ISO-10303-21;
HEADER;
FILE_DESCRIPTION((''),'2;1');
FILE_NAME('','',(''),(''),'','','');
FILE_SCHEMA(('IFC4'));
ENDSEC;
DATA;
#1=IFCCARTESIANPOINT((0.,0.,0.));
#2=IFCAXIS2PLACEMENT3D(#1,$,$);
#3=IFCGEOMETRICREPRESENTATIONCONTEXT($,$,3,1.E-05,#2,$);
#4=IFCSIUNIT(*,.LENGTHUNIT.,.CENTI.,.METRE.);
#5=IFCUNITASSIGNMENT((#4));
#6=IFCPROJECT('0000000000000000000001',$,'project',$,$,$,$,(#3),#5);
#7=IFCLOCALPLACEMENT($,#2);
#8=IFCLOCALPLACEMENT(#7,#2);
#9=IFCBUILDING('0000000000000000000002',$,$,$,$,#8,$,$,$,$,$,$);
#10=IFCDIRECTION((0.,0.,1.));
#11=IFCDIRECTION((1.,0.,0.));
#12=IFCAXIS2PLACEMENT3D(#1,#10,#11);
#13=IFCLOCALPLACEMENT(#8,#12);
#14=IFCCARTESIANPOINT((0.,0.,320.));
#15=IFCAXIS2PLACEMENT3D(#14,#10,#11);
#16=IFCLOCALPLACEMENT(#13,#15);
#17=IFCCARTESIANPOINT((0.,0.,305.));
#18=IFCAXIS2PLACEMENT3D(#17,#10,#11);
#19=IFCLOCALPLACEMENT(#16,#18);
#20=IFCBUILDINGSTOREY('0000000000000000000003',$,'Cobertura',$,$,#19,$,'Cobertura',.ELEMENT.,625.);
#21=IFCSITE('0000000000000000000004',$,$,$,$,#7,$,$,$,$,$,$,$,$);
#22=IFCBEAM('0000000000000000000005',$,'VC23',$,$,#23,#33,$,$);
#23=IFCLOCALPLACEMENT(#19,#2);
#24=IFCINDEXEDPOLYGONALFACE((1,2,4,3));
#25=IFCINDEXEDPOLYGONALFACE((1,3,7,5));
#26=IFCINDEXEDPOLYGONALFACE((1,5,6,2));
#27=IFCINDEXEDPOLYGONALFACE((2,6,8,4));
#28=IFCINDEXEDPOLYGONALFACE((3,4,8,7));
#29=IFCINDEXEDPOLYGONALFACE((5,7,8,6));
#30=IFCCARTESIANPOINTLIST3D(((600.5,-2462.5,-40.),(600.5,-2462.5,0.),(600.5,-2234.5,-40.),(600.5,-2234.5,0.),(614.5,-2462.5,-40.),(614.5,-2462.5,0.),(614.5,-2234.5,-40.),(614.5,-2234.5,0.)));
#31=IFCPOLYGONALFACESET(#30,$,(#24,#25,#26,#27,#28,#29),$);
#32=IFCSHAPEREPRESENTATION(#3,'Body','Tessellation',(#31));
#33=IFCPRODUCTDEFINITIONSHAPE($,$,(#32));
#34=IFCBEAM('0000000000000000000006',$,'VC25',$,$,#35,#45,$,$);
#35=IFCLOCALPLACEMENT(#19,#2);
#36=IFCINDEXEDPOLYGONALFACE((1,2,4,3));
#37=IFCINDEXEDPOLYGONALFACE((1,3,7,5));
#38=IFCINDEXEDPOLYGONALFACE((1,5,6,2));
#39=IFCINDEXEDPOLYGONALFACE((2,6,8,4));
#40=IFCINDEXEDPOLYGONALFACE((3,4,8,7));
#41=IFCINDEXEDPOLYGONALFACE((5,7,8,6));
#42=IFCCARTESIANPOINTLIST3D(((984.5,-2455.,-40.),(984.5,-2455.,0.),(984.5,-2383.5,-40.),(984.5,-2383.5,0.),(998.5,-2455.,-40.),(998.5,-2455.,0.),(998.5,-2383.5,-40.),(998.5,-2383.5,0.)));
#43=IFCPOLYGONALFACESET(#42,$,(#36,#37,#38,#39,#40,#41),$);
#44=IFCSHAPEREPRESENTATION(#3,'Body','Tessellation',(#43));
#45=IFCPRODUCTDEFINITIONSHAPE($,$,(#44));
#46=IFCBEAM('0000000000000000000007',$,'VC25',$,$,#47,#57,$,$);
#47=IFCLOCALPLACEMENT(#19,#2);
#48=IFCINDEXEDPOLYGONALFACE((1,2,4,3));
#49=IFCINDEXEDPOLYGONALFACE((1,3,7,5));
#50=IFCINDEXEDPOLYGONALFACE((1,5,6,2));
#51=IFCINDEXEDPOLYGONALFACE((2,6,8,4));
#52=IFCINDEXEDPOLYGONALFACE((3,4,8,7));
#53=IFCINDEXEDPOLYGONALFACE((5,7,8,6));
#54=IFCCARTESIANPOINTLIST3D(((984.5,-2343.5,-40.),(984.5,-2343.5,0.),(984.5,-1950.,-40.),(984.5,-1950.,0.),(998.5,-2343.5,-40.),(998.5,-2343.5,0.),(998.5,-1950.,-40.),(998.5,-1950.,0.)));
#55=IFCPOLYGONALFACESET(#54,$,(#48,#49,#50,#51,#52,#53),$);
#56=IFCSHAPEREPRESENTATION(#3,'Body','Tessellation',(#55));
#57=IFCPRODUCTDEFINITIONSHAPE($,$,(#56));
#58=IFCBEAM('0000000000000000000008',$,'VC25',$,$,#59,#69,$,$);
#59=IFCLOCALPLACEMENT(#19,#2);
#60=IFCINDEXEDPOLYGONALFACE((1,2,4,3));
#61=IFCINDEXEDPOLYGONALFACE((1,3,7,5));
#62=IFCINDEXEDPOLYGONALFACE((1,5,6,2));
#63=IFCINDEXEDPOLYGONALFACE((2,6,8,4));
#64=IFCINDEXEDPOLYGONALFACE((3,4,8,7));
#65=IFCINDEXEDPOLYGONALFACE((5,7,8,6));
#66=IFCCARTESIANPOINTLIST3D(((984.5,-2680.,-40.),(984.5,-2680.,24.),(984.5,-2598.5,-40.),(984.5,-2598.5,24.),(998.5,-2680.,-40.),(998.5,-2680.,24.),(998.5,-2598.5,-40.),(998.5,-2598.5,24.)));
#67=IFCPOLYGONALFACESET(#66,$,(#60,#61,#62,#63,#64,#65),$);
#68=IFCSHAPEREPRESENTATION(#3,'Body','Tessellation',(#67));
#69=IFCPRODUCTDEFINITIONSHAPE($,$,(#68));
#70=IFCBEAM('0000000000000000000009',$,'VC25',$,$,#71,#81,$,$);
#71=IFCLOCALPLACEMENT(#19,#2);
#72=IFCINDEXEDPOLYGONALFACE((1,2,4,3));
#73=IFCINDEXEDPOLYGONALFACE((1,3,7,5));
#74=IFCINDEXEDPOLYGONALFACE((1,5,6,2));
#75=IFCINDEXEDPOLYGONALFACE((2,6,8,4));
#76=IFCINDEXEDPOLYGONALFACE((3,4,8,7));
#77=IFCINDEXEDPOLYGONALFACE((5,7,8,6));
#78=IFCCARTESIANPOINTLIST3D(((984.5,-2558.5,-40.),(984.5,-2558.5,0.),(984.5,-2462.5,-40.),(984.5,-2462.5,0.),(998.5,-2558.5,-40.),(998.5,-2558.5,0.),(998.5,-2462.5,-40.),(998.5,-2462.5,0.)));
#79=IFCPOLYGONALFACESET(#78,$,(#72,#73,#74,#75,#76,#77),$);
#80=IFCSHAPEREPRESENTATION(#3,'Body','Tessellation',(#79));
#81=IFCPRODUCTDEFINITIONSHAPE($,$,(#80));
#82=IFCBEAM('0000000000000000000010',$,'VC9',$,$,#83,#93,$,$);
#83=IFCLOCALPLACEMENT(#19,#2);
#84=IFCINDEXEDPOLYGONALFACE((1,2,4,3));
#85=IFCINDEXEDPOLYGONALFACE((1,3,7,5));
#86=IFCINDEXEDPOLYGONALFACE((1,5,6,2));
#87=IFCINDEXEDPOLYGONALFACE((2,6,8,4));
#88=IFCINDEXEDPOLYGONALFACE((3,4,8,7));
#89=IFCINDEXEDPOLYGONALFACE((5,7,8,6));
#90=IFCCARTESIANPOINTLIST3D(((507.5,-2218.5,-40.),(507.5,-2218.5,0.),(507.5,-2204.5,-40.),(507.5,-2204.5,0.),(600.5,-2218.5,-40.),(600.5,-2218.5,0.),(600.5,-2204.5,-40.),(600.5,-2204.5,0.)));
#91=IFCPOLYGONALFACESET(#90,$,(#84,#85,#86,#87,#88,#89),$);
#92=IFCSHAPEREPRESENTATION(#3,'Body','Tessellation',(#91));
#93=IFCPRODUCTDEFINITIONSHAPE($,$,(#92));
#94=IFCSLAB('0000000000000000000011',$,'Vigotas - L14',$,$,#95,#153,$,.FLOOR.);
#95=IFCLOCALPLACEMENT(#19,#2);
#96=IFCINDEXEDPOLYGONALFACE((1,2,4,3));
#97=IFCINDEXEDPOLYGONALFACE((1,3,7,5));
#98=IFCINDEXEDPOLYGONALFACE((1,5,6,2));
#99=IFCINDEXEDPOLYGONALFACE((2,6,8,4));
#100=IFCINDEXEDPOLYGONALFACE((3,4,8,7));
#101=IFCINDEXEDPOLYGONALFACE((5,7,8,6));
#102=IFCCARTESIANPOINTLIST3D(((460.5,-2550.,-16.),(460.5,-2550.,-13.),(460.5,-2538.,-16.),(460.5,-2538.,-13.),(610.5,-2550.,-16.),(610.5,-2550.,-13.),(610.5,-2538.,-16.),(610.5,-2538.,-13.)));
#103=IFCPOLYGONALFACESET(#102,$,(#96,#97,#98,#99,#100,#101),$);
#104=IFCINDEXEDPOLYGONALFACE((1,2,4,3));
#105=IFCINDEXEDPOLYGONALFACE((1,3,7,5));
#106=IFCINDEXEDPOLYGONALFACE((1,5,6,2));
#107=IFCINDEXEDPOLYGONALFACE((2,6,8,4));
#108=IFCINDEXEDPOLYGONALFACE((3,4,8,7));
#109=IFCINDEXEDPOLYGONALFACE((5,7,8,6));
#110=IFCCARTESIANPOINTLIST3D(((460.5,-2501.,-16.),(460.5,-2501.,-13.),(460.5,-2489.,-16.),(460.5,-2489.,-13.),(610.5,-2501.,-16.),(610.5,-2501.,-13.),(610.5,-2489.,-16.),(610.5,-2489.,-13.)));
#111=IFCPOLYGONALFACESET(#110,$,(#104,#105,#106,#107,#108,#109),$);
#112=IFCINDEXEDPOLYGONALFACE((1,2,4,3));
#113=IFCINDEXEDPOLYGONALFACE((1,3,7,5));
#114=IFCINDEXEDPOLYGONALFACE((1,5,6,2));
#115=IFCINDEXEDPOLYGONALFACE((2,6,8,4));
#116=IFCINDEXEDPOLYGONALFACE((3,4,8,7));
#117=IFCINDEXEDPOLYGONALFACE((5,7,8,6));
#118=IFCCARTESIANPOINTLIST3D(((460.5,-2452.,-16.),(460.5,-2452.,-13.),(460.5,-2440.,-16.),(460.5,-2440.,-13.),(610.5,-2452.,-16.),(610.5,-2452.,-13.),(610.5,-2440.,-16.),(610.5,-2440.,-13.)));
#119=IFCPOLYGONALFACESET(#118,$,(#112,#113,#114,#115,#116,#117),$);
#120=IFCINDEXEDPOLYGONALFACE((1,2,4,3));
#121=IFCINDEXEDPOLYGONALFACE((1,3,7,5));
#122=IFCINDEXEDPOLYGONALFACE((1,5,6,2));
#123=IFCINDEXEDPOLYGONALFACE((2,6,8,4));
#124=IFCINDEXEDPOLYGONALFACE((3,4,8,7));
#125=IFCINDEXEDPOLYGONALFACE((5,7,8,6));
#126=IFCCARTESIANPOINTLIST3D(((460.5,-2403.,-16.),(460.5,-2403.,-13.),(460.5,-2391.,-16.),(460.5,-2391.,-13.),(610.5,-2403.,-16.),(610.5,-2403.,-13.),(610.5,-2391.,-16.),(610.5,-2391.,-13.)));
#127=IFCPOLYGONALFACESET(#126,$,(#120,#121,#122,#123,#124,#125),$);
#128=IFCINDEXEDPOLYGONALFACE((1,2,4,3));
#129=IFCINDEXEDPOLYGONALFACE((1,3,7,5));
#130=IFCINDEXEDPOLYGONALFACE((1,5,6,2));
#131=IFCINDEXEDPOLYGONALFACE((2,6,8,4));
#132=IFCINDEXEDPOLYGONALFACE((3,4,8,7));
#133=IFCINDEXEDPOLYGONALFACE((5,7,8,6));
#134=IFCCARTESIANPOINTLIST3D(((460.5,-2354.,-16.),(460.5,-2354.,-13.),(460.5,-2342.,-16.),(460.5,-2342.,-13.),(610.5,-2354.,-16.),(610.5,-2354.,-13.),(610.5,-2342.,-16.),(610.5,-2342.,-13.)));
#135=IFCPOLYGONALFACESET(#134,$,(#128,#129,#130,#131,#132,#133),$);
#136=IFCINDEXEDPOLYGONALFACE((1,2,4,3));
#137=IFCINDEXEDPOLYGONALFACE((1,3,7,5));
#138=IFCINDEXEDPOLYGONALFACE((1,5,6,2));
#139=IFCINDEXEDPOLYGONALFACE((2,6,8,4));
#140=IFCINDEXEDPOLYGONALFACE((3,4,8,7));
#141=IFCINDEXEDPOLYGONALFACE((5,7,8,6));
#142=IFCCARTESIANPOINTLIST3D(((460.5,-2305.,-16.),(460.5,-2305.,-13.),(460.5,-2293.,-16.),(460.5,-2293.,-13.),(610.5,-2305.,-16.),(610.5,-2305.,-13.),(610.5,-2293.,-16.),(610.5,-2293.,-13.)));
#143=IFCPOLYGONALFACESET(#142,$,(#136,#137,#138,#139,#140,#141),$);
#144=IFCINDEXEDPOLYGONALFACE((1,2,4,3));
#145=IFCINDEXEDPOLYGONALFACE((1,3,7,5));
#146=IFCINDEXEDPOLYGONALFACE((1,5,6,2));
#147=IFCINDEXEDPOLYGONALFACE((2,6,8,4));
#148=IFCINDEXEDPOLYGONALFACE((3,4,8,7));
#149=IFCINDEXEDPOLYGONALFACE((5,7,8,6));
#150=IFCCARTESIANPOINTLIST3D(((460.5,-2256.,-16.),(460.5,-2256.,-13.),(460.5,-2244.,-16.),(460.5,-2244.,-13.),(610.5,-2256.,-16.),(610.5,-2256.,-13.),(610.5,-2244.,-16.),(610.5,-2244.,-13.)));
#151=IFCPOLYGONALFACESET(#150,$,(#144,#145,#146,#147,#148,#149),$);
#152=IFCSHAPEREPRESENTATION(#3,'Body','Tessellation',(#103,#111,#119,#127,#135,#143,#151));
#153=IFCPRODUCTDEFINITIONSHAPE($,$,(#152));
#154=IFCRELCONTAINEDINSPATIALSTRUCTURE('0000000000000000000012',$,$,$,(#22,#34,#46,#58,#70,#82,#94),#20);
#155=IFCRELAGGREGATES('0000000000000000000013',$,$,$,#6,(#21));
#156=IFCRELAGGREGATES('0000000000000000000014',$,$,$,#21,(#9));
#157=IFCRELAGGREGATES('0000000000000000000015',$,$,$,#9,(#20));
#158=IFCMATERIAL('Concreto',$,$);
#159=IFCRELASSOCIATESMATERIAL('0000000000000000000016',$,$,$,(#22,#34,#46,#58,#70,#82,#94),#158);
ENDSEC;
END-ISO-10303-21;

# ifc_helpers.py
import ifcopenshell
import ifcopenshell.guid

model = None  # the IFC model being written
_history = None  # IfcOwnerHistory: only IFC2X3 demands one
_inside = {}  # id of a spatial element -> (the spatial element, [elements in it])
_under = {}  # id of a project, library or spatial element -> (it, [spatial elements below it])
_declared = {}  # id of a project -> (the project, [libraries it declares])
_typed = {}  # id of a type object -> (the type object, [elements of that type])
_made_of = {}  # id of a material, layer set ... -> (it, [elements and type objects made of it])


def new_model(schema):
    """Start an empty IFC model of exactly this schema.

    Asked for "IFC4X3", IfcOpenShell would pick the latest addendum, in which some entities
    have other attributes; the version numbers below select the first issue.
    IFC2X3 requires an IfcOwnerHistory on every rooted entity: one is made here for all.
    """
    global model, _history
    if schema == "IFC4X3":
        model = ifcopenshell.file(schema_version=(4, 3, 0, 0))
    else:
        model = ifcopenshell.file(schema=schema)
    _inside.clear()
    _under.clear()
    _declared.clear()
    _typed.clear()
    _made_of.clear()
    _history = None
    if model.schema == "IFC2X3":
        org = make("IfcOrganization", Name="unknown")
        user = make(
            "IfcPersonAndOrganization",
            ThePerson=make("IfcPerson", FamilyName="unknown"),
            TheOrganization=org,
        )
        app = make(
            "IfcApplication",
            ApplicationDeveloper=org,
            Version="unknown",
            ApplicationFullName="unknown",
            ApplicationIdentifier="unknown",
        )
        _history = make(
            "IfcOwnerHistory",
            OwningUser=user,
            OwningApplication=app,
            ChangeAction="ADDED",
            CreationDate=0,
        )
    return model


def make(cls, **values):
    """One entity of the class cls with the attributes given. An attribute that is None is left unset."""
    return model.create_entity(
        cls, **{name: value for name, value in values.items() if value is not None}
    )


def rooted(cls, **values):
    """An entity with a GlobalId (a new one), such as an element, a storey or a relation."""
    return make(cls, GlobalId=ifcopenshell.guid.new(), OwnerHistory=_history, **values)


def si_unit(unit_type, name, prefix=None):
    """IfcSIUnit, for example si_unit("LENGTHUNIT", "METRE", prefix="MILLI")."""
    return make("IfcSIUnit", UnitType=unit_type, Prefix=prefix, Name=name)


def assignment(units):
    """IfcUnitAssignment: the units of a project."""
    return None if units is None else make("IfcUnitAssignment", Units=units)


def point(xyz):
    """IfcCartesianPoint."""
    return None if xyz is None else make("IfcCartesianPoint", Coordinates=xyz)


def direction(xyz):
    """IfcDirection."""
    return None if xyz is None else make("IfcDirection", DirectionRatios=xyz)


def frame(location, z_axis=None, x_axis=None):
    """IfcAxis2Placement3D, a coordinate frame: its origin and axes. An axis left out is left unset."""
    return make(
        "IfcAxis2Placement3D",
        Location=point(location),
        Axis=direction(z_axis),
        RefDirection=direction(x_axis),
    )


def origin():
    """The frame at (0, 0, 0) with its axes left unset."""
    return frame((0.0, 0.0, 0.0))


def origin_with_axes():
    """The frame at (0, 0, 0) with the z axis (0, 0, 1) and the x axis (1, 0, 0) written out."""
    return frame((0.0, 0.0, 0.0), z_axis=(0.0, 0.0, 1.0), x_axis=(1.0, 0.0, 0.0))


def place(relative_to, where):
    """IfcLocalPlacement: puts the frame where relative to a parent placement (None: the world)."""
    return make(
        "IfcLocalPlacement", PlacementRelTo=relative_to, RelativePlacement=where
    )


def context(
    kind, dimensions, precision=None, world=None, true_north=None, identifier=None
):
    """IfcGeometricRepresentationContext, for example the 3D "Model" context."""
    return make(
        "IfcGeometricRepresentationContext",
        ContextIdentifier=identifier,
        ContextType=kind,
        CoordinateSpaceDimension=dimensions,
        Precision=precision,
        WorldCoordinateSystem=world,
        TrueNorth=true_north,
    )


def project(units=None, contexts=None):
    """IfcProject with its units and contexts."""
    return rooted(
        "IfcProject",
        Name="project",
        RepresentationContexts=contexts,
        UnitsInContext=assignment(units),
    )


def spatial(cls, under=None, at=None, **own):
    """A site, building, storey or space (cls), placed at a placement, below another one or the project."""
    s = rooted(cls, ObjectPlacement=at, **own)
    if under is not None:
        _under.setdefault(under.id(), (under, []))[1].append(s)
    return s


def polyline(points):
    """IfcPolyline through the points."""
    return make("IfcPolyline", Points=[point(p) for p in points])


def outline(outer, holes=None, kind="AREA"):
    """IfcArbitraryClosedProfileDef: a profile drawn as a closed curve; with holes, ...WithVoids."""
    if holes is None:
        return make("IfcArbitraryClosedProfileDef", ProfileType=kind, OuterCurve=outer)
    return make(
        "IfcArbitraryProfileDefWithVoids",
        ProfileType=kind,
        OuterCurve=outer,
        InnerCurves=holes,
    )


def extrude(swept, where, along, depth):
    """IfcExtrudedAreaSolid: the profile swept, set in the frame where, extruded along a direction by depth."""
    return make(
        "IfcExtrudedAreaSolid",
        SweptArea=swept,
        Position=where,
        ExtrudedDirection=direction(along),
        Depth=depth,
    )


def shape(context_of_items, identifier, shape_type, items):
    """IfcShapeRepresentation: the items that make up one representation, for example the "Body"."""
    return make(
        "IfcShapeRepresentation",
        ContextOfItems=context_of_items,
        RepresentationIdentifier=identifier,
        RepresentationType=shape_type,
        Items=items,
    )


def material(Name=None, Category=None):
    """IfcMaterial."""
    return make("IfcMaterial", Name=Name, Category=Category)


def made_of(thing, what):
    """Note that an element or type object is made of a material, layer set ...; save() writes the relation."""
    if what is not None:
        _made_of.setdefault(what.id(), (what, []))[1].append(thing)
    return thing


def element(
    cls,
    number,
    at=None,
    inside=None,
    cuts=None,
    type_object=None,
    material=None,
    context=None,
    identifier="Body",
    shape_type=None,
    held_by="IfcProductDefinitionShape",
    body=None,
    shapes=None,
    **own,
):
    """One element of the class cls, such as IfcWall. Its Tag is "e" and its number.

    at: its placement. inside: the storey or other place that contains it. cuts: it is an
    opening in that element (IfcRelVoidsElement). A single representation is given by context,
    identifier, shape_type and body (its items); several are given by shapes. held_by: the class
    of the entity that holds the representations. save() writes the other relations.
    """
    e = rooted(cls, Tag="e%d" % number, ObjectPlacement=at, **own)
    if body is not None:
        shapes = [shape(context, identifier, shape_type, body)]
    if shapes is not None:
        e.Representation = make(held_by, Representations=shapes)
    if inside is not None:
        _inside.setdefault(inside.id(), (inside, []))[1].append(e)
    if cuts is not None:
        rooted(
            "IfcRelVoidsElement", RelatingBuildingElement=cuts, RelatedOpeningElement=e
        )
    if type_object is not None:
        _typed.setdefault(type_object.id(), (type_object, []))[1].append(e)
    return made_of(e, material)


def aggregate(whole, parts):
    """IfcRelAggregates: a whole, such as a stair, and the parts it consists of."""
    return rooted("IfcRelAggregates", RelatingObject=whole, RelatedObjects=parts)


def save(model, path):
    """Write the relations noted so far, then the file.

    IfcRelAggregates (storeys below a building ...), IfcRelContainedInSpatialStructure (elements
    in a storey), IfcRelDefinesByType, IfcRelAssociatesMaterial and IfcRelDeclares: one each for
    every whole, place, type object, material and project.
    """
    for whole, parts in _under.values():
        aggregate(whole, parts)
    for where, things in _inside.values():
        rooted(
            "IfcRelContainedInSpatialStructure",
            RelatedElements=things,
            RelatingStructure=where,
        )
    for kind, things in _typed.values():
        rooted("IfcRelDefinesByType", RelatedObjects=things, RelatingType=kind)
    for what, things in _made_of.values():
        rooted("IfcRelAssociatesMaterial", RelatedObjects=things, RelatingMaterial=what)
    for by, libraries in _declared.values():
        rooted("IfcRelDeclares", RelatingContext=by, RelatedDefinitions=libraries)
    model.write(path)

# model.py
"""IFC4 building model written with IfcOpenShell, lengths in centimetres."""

from ifc_helpers import new_model, si_unit, frame, origin, origin_with_axes, place, context, project, spatial, polyline, outline, extrude, material, element, save


model = new_model("IFC4")

# Units and contexts
context_of_model = context(None, 3, precision=1e-05, world=origin())
ifc_project = project(units=[si_unit("LENGTHUNIT", "METRE", prefix="CENTI")], contexts=[context_of_model])

# Site, building, storey
site_placement = place(None, origin())
site = spatial("IfcSite", under=ifc_project, at=site_placement)
building_placement = place(site_placement, origin())
building = spatial("IfcBuilding", under=site, at=building_placement)
placement_1 = place(building_placement, origin_with_axes())
placement_2 = place(placement_1, frame((0.0, 0.0, 320.0), z_axis=(0.0, 0.0, 1.0), x_axis=(1.0, 0.0, 0.0)))
storey_placement = place(placement_2, frame((0.0, 0.0, 305.0), z_axis=(0.0, 0.0, 1.0), x_axis=(1.0, 0.0, 0.0)))
storey = spatial("IfcBuildingStorey", under=building, at=storey_placement, Name="Cobertura", LongName="Cobertura", CompositionType="ELEMENT", Elevation=625.0)

# Shared definitions
ifc_material = material(Name="Concreto")

# Beams
beam_1_placement = place(storey_placement, frame((607.5, -2348.5, 0.0), z_axis=(0.0, 0.0, 1.0), x_axis=(1.0, 0.0, 0.0)))
element("IfcBeam", 1, at=beam_1_placement, inside=storey, material=ifc_material, Name="VC23", context=context_of_model, shape_type="SolidModel", body=[
    extrude(outline(polyline([(-7.0, -20.0), (7.0, -20.0), (7.0, 20.0), (-7.0, 20.0), (-7.0, -20.0)])), frame((0.0, -114.0, -20.0), z_axis=(0.0, 1.0, 0.0), x_axis=(1.0, 0.0, 0.0)), (0.0, 0.0, 1.0), 228.0),
])
beam_2_placement = place(storey_placement, frame((991.5, -2419.25, 0.0), z_axis=(0.0, 0.0, 1.0), x_axis=(1.0, 0.0, 0.0)))
element("IfcBeam", 2, at=beam_2_placement, inside=storey, material=ifc_material, Name="VC25", context=context_of_model, shape_type="SolidModel", body=[
    extrude(outline(polyline([(-7.0, -20.0), (7.0, -20.0), (7.0, 20.0), (-7.0, 20.0), (-7.0, -20.0)])), frame((0.0, -35.75, -20.0), z_axis=(0.0, 1.0, 0.0), x_axis=(1.0, 0.0, 0.0)), (0.0, 0.0, 1.0), 71.5),
])
beam_3_placement = place(storey_placement, frame((991.5, -2146.75, 0.0), z_axis=(0.0, 0.0, 1.0), x_axis=(1.0, 0.0, 0.0)))
element("IfcBeam", 3, at=beam_3_placement, inside=storey, material=ifc_material, Name="VC25", context=context_of_model, shape_type="SolidModel", body=[
    extrude(outline(polyline([(-7.0, -20.0), (7.0, -20.0), (7.0, 20.0), (-7.0, 20.0), (-7.0, -20.0)])), frame((0.0, -196.75, -20.0), z_axis=(0.0, 1.0, 0.0), x_axis=(1.0, 0.0, 0.0)), (0.0, 0.0, 1.0), 393.5),
])
beam_4_placement = place(storey_placement, frame((991.5, -2639.25, 24.0), z_axis=(0.0, 0.0, 1.0), x_axis=(1.0, 0.0, 0.0)))
element("IfcBeam", 4, at=beam_4_placement, inside=storey, material=ifc_material, Name="VC25", context=context_of_model, shape_type="SolidModel", body=[
    extrude(outline(polyline([(-7.0, -32.0), (7.0, -32.0), (7.0, 32.0), (-7.0, 32.0), (-7.0, -32.0)])), frame((0.0, -40.75, -32.0), z_axis=(0.0, 1.0, 0.0), x_axis=(1.0, 0.0, 0.0)), (0.0, 0.0, 1.0), 81.5),
])
beam_5_placement = place(storey_placement, frame((991.5, -2510.5, 0.0), z_axis=(0.0, 0.0, 1.0), x_axis=(1.0, 0.0, 0.0)))
element("IfcBeam", 5, at=beam_5_placement, inside=storey, material=ifc_material, Name="VC25", context=context_of_model, shape_type="SolidModel", body=[
    extrude(outline(polyline([(-7.0, -20.0), (7.0, -20.0), (7.0, 20.0), (-7.0, 20.0), (-7.0, -20.0)])), frame((0.0, -48.0, -20.0), z_axis=(0.0, 1.0, 0.0), x_axis=(1.0, 0.0, 0.0)), (0.0, 0.0, 1.0), 96.0),
])
beam_6_placement = place(storey_placement, frame((554.0, -2211.5, 0.0), z_axis=(0.0, 0.0, 1.0), x_axis=(1.0, 0.0, 0.0)))
element("IfcBeam", 6, at=beam_6_placement, inside=storey, material=ifc_material, Name="VC9", context=context_of_model, shape_type="SolidModel", body=[
    extrude(outline(polyline([(-7.0, -20.0), (7.0, -20.0), (7.0, 20.0), (-7.0, 20.0), (-7.0, -20.0)])), frame((-46.5, 0.0, -20.0), z_axis=(1.0, 0.0, 0.0), x_axis=(0.0, -1.0, 0.0)), (0.0, 0.0, 1.0), 93.0),
])

# Slab
slab_1_placement = place(storey_placement, frame((535.5, -2397.0, -13.0), z_axis=(0.0, 0.0, 1.0), x_axis=(1.0, 0.0, 0.0)))
element("IfcSlab", 7, at=slab_1_placement, inside=storey, material=ifc_material, Name="Vigotas - L14", PredefinedType="FLOOR", context=context_of_model, shape_type="SolidModel", body=[
    extrude(outline(polyline([(6.0, 1.5), (-6.0, 1.5), (-6.0, -1.5), (6.0, -1.5), (6.0, 1.5), (6.0, 1.5)])), frame((-75.0, -147.0, -1.5), z_axis=(1.0, 0.0, 0.0), x_axis=(0.0, -1.0, 0.0)), (0.0, 0.0, 1.0), 150.0),
    extrude(outline(polyline([(6.0, 1.5), (-6.0, 1.5), (-6.0, -1.5), (6.0, -1.5), (6.0, 1.5), (6.0, 1.5)])), frame((-75.0, -98.0, -1.5), z_axis=(1.0, 0.0, 0.0), x_axis=(0.0, -1.0, 0.0)), (0.0, 0.0, 1.0), 150.0),
    extrude(outline(polyline([(6.0, 1.5), (-6.0, 1.5), (-6.0, -1.5), (6.0, -1.5), (6.0, 1.5), (6.0, 1.5)])), frame((-75.0, -49.0, -1.5), z_axis=(1.0, 0.0, 0.0), x_axis=(0.0, -1.0, 0.0)), (0.0, 0.0, 1.0), 150.0),
    extrude(outline(polyline([(6.0, 1.5), (-6.0, 1.5), (-6.0, -1.5), (6.0, -1.5), (6.0, 1.5), (6.0, 1.5)])), frame((-75.0, 0.0, -1.5), z_axis=(1.0, 0.0, 0.0), x_axis=(0.0, -1.0, 0.0)), (0.0, 0.0, 1.0), 150.0),
    extrude(outline(polyline([(6.0, 1.5), (-6.0, 1.5), (-6.0, -1.5), (6.0, -1.5), (6.0, 1.5), (6.0, 1.5)])), frame((-75.0, 49.0, -1.5), z_axis=(1.0, 0.0, 0.0), x_axis=(0.0, -1.0, 0.0)), (0.0, 0.0, 1.0), 150.0),
    extrude(outline(polyline([(6.0, 1.5), (-6.0, 1.5), (-6.0, -1.5), (6.0, -1.5), (6.0, 1.5), (6.0, 1.5)])), frame((-75.0, 98.0, -1.5), z_axis=(1.0, 0.0, 0.0), x_axis=(0.0, -1.0, 0.0)), (0.0, 0.0, 1.0), 150.0),
    extrude(outline(polyline([(6.0, 1.5), (-6.0, 1.5), (-6.0, -1.5), (6.0, -1.5), (6.0, 1.5), (6.0, 1.5)])), frame((-75.0, 147.0, -1.5), z_axis=(1.0, 0.0, 0.0), x_axis=(0.0, -1.0, 0.0)), (0.0, 0.0, 1.0), 150.0),
])

save(model, "model.ifc")
